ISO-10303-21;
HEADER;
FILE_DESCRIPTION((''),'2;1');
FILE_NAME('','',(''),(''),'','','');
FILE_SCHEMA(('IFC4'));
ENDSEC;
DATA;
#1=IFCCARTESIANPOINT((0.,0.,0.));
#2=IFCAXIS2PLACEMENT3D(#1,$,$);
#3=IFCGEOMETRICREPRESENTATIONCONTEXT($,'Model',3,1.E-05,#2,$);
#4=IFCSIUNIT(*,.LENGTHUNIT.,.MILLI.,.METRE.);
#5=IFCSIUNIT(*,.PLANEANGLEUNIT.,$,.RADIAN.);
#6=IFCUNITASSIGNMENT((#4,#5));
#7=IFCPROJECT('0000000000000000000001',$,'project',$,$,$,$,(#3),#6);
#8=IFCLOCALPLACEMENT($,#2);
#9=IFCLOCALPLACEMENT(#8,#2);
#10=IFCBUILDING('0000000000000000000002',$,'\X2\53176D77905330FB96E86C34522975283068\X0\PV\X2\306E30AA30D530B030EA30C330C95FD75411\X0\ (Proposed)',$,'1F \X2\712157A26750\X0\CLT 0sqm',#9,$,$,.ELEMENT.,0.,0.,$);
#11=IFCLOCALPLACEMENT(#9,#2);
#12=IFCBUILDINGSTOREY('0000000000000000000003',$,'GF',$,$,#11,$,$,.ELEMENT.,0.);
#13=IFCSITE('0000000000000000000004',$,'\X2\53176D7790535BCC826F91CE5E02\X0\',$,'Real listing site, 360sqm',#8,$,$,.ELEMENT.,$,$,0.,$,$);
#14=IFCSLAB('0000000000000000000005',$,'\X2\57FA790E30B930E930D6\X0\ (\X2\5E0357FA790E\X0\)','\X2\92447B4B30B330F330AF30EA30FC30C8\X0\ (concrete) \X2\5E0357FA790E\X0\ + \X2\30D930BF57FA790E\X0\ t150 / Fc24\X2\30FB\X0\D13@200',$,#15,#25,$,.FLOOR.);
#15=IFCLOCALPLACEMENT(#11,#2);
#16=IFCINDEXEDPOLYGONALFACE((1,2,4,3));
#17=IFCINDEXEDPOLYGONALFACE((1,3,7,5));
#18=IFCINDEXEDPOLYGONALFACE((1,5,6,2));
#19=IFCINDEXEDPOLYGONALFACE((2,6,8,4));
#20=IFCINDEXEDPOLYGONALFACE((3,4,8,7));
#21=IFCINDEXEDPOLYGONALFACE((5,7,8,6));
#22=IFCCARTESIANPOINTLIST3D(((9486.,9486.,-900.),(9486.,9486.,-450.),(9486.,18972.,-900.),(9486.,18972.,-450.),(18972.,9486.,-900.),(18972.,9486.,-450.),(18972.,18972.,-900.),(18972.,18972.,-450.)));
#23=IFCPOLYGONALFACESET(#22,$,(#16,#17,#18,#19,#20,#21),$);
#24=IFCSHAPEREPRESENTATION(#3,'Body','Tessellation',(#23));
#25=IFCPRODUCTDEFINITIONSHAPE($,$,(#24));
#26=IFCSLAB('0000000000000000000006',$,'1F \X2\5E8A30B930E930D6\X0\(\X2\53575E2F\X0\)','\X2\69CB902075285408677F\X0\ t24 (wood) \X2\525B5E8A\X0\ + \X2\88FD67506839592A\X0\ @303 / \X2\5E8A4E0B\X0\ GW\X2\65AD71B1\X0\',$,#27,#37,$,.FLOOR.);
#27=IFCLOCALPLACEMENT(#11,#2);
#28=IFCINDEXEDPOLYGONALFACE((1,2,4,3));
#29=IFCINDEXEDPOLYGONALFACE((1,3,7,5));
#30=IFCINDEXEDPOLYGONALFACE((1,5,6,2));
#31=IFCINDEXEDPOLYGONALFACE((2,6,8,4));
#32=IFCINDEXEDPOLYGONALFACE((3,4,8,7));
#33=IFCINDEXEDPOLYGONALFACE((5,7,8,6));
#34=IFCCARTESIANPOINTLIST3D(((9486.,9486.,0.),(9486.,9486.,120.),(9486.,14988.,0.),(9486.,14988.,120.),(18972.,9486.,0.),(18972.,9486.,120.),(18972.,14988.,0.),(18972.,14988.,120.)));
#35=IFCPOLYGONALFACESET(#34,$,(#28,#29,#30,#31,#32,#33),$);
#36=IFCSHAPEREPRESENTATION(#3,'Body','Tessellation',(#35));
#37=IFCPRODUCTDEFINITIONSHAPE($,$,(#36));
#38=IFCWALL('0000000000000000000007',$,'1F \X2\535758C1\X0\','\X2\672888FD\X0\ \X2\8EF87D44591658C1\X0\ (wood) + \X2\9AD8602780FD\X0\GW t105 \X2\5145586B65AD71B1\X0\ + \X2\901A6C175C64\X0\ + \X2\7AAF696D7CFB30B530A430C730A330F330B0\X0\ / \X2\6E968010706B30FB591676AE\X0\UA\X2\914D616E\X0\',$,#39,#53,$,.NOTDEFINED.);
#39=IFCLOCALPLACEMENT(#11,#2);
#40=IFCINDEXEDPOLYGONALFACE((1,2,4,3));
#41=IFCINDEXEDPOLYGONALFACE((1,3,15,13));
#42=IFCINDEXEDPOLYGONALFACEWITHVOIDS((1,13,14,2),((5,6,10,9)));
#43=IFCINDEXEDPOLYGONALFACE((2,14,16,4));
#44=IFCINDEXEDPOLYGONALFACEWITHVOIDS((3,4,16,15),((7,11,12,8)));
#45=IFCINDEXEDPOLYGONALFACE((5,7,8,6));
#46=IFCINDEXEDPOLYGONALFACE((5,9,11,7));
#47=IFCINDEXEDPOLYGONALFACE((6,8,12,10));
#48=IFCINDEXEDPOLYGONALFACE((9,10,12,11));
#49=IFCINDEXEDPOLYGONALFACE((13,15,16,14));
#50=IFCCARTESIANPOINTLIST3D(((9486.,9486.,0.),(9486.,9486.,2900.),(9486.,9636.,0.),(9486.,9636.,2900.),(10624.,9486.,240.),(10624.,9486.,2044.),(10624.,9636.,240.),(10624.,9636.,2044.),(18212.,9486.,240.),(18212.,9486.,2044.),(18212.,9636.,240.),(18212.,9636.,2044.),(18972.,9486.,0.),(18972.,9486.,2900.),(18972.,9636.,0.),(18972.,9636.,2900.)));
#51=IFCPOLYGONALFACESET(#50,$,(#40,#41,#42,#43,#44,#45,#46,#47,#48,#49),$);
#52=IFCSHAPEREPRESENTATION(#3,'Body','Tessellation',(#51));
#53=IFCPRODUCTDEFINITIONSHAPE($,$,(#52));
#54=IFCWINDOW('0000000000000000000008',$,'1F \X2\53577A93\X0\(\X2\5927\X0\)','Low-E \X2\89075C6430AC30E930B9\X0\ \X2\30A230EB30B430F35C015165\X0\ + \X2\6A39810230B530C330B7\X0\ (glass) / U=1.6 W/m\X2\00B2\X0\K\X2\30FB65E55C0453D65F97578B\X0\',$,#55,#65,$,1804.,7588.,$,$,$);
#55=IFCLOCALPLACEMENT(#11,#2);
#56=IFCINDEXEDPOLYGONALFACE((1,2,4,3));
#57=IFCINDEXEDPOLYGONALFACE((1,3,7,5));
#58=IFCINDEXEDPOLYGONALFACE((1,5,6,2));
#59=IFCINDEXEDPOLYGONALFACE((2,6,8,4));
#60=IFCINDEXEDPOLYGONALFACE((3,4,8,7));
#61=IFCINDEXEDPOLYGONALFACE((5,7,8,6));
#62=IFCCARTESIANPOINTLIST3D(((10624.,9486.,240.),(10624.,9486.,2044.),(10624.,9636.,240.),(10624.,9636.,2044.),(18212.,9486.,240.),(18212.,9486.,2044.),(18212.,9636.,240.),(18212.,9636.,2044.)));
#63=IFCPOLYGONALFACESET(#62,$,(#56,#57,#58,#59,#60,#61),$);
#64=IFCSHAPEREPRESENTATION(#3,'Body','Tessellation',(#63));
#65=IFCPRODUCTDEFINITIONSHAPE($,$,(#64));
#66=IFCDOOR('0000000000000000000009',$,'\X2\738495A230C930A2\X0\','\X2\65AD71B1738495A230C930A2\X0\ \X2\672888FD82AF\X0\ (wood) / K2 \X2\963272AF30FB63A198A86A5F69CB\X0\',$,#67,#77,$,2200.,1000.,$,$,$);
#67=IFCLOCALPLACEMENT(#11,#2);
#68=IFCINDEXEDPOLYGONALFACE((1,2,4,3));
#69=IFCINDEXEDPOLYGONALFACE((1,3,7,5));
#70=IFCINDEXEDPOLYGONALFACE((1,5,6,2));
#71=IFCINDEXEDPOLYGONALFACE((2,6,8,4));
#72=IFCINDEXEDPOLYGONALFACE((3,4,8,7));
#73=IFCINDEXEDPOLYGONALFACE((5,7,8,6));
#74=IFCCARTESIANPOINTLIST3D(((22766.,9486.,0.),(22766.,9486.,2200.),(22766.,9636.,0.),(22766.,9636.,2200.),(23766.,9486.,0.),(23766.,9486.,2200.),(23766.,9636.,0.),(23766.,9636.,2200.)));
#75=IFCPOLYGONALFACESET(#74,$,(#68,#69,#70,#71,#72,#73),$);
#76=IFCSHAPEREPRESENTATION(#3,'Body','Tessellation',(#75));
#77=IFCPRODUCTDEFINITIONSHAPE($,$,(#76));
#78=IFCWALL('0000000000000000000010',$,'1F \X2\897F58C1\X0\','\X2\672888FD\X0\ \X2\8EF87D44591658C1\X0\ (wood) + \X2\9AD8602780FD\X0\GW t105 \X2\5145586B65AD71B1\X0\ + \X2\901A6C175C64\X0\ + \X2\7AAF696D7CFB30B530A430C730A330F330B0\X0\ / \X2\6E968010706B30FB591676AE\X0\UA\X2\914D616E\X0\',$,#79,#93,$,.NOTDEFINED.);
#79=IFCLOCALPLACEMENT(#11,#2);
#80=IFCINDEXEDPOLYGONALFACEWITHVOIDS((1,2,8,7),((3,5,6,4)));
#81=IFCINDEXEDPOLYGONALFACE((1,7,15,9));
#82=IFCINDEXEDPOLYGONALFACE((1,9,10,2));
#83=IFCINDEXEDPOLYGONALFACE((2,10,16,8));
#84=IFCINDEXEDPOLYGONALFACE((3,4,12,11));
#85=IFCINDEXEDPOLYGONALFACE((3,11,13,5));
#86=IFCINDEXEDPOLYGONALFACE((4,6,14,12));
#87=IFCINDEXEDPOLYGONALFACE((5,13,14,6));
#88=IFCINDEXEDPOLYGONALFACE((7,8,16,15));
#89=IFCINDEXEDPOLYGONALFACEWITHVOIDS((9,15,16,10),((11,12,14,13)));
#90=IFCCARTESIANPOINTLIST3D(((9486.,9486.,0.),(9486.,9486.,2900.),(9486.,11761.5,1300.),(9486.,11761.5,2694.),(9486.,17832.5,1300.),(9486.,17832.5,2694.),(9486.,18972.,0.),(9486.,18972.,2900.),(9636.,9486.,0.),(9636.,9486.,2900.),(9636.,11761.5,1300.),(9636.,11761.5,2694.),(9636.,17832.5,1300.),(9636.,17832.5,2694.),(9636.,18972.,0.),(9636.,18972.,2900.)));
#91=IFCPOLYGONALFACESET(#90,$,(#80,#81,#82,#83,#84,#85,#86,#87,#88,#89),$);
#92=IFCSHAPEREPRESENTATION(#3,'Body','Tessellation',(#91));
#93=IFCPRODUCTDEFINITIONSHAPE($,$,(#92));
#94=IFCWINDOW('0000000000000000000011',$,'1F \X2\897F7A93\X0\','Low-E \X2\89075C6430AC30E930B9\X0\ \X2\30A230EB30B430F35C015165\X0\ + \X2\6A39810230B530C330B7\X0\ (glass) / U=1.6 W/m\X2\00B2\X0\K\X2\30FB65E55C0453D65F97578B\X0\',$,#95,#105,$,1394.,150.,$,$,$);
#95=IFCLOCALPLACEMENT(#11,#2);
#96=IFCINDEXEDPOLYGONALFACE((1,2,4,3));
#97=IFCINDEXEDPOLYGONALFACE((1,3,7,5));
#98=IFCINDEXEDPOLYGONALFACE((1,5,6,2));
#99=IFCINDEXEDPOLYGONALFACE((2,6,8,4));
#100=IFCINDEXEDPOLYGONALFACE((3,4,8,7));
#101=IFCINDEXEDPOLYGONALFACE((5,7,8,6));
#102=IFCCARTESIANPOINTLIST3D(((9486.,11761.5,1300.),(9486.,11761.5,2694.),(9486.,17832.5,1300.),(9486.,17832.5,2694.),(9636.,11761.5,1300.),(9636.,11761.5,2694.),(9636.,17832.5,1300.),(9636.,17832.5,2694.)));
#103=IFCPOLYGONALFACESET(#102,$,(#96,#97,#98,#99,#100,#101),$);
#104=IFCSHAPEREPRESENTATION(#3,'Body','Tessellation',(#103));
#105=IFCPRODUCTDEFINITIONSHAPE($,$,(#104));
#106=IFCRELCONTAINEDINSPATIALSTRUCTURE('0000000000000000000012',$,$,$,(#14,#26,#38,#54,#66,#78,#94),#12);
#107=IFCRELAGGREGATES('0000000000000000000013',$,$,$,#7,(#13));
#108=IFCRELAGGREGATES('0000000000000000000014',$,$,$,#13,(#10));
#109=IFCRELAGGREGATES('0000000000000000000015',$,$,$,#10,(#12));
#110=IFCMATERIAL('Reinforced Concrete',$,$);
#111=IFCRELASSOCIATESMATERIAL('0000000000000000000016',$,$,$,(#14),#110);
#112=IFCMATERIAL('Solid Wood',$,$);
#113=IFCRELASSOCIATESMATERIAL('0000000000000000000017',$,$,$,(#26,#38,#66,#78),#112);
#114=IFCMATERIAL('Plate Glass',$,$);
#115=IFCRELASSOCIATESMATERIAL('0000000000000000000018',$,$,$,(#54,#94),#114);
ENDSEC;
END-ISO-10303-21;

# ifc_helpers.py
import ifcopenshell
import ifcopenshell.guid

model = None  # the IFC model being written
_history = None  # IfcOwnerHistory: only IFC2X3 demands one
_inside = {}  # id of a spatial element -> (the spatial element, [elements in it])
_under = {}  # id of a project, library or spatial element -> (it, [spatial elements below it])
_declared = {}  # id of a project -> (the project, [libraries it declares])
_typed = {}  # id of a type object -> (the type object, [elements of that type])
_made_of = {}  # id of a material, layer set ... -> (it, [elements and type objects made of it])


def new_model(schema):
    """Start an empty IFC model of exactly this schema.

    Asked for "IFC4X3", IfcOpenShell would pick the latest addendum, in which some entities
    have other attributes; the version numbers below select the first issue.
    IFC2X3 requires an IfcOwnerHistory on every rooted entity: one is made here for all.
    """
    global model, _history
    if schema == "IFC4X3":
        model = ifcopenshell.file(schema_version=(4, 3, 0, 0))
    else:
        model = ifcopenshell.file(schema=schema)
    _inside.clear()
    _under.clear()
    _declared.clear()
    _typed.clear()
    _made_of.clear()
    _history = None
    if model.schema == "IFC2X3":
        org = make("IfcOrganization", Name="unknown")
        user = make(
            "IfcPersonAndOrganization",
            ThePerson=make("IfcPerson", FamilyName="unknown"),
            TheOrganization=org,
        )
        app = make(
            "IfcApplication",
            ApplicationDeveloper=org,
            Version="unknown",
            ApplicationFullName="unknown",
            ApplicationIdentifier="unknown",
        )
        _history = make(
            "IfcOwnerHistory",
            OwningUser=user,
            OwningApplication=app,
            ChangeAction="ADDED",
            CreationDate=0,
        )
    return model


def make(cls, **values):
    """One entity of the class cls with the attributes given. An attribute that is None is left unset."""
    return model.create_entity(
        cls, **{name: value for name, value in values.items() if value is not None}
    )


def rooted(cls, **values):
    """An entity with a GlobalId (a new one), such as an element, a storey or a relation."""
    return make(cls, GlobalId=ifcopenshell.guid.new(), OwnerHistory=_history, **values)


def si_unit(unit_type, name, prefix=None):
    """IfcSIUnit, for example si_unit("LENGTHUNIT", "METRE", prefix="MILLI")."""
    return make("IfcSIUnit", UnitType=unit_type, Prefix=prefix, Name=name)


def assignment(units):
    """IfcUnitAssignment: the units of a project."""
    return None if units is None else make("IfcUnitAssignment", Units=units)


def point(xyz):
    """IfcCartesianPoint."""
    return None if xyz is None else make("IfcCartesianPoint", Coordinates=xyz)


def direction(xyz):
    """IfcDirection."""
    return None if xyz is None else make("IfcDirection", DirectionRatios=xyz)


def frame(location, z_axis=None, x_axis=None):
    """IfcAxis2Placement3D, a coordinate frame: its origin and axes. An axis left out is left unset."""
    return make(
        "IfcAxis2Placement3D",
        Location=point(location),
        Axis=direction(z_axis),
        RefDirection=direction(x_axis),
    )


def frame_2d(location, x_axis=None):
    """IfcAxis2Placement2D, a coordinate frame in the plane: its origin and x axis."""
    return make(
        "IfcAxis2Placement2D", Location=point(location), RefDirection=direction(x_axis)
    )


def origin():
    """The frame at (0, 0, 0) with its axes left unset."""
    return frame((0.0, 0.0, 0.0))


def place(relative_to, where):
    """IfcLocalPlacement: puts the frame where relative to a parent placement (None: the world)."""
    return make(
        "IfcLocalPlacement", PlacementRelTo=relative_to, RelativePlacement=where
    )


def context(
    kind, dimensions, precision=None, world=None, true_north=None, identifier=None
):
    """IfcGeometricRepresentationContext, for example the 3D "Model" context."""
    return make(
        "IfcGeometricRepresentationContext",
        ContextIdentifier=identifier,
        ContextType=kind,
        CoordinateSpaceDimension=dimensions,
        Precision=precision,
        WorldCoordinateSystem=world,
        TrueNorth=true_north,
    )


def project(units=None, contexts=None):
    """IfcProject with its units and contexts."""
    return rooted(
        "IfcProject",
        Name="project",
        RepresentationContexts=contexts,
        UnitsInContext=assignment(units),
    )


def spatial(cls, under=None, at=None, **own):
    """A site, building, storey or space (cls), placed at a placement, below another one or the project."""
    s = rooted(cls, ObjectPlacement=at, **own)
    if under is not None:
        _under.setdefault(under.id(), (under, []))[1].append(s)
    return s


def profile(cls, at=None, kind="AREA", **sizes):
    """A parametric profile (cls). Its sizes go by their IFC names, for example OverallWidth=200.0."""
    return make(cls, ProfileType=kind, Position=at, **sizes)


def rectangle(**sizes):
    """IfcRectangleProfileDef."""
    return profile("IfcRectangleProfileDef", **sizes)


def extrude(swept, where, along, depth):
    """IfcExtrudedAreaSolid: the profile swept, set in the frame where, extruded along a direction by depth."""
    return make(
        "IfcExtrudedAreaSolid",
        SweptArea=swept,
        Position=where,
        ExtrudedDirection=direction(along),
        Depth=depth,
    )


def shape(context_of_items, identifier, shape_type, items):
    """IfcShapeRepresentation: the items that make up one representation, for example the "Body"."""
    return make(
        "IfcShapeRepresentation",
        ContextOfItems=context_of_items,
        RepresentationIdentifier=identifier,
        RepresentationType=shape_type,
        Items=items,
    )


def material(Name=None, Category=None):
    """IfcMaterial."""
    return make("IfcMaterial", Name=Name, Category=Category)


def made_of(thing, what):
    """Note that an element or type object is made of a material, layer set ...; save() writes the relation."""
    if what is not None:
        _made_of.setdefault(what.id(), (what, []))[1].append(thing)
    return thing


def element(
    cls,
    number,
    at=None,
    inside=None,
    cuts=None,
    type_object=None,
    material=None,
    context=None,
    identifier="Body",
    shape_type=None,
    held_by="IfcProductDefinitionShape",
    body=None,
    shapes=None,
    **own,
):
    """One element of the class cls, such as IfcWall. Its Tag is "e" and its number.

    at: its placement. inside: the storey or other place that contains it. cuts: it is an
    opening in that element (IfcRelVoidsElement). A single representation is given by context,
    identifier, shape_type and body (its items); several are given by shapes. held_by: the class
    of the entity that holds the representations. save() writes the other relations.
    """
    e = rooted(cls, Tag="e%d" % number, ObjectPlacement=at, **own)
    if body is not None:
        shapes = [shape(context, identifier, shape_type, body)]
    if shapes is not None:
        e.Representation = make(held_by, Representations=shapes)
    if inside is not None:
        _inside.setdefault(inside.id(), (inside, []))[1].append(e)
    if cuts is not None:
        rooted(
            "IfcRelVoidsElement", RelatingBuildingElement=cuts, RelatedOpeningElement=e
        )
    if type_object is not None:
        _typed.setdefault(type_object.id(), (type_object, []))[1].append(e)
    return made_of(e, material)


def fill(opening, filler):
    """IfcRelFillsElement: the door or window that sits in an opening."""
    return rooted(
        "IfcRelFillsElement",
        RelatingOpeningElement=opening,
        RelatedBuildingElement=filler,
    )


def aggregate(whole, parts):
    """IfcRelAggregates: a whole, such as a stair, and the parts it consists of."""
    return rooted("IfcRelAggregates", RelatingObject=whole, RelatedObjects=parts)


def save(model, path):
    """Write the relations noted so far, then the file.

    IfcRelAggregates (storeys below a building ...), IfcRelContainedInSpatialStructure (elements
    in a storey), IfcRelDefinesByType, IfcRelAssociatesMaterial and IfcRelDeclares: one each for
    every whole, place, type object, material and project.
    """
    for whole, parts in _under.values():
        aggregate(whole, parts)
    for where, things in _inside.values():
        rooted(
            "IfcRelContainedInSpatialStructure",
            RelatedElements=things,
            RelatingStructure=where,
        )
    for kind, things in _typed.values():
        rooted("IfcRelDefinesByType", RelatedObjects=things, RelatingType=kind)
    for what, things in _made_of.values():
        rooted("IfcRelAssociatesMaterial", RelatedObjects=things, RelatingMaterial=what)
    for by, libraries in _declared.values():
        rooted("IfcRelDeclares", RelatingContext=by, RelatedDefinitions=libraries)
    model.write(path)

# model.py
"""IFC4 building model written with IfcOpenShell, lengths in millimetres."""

from ifc_helpers import new_model, si_unit, frame, frame_2d, origin, place, context, project, spatial, rectangle, extrude, material, element, fill, save


model = new_model("IFC4")

# Units and contexts
model_context = context("Model", 3, precision=1e-05, world=origin())
ifc_project = project(units=[si_unit("LENGTHUNIT", "METRE", prefix="MILLI"), si_unit("PLANEANGLEUNIT", "RADIAN")], contexts=[model_context])

# Site, building, storey
site_placement = place(None, origin())
site = spatial("IfcSite", under=ifc_project, at=site_placement, Name="北海道富良野市", ObjectType="Real listing site, 360sqm", CompositionType="ELEMENT", RefElevation=0.0)
building_placement = place(site_placement, origin())
building = spatial("IfcBuilding", under=site, at=building_placement, Name="北海道・雨水利用とPVのオフグリッド志向 (Proposed)", ObjectType="1F 無垢材CLT 0sqm", CompositionType="ELEMENT", ElevationOfRefHeight=0.0, ElevationOfTerrain=0.0)
storey_placement = place(building_placement, origin())
storey = spatial("IfcBuildingStorey", under=building, at=storey_placement, Name="GF", CompositionType="ELEMENT", Elevation=0.0)

# Slabs
ifc_material_1 = material(Name="Reinforced Concrete")
slab_1_placement = place(storey_placement, frame((4743.0, 4743.0, -450.0)))
element("IfcSlab", 1, at=slab_1_placement, inside=storey, material=ifc_material_1, Name="基礎スラブ (布基礎)", Description="鉄筋コンクリート (concrete) 布基礎 + ベタ基礎 t150 / Fc24・D13@200", PredefinedType="FLOOR", context=model_context, shape_type="SweptSolid", body=[
    extrude(rectangle(XDim=9486.0, YDim=9486.0, at=frame_2d((4743.0, 4743.0))), frame((4743.0, 4743.0, -450.0)), (0.0, 0.0, 1.0), 450.0),
])
ifc_material_2 = material(Name="Solid Wood")
slab_2_placement = place(storey_placement, frame((4743.0, 4743.0, 0.0)))
element("IfcSlab", 2, at=slab_2_placement, inside=storey, material=ifc_material_2, Name="1F 床スラブ(南帯)", Description="構造用合板 t24 (wood) 剛床 + 製材根太 @303 / 床下 GW断熱", PredefinedType="FLOOR", context=model_context, shape_type="SweptSolid", body=[
    extrude(rectangle(XDim=9486.0, YDim=5502.0, at=frame_2d((4743.0, 2751.0))), frame((4743.0, 4743.0, 0.0)), (0.0, 0.0, 1.0), 120.0),
])

# Wall, openings, window, door
wall_1_placement = place(storey_placement, frame((4743.0, 4743.0, 0.0)))
wall_1 = element("IfcWall", 3, at=wall_1_placement, inside=storey, material=ifc_material_2, Name="1F 南壁", Description="木製 軸組外壁 (wood) + 高性能GW t105 充填断熱 + 通気層 + 窯業系サイディング / 準耐火・外皮UA配慮", PredefinedType="NOTDEFINED", context=model_context, shape_type="SweptSolid", body=[
    extrude(rectangle(XDim=9486.0, YDim=150.0, at=frame_2d((4743.0, 75.0))), frame((4743.0, 4743.0, 0.0)), (0.0, 0.0, 1.0), 2900.0),
])
opening_1_placement = place(storey_placement, frame((5312.0, 4743.0, 120.0)))
opening_1 = element("IfcOpeningElement", 4, at=opening_1_placement, cuts=wall_1, PredefinedType="NOTDEFINED", context=model_context, shape_type="SweptSolid", body=[
    extrude(rectangle(XDim=7588.0, YDim=150.0, at=frame_2d((3794.0, 75.0))), frame((5312.0, 4743.0, 120.0)), (0.0, 0.0, 1.0), 1804.0),
])
opening_2_placement = place(storey_placement, frame((11383.0, 4743.0, 0.0)))
opening_2 = element("IfcOpeningElement", 5, at=opening_2_placement, cuts=wall_1, PredefinedType="NOTDEFINED", context=model_context, shape_type="SweptSolid", body=[
    extrude(rectangle(XDim=1000.0, YDim=150.0, at=frame_2d((500.0, 75.0))), frame((11383.0, 4743.0, 0.0)), (0.0, 0.0, 1.0), 2200.0),
])
ifc_material_3 = material(Name="Plate Glass")
window_1_placement = place(storey_placement, frame((5312.0, 4743.0, 120.0)))
window_1 = element("IfcWindow", 6, at=window_1_placement, inside=storey, material=ifc_material_3, Name="1F 南窓(大)", Description="Low-E 複層ガラス アルゴン封入 + 樹脂サッシ (glass) / U=1.6 W/m²K・日射取得型", OverallHeight=1804.0, OverallWidth=7588.0, context=model_context, shape_type="SweptSolid", body=[
    extrude(rectangle(XDim=7588.0, YDim=150.0, at=frame_2d((3794.0, 75.0))), frame((5312.0, 4743.0, 120.0)), (0.0, 0.0, 1.0), 1804.0),
])
fill(opening_1, window_1)
door_placement = place(storey_placement, frame((11383.0, 4743.0, 0.0)))
door = element("IfcDoor", 7, at=door_placement, inside=storey, material=ifc_material_2, Name="玄関ドア", Description="断熱玄関ドア 木製芯 (wood) / K2 防犯・採風機構", OverallHeight=2200.0, OverallWidth=1000.0, context=model_context, shape_type="SweptSolid", body=[
    extrude(rectangle(XDim=1000.0, YDim=150.0, at=frame_2d((500.0, 75.0))), frame((11383.0, 4743.0, 0.0)), (0.0, 0.0, 1.0), 2200.0),
])
fill(opening_2, door)

# Wall, opening, window
wall_2_placement = place(storey_placement, frame((4743.0, 4743.0, 0.0)))
wall_2 = element("IfcWall", 8, at=wall_2_placement, inside=storey, material=ifc_material_2, Name="1F 西壁", Description="木製 軸組外壁 (wood) + 高性能GW t105 充填断熱 + 通気層 + 窯業系サイディング / 準耐火・外皮UA配慮", PredefinedType="NOTDEFINED", context=model_context, shape_type="SweptSolid", body=[
    extrude(rectangle(XDim=150.0, YDim=9486.0, at=frame_2d((75.0, 4743.0))), frame((4743.0, 4743.0, 0.0)), (0.0, 0.0, 1.0), 2900.0),
])
opening_3_placement = place(storey_placement, frame((4743.0, 5881.0, 650.0)))
opening_3 = element("IfcOpeningElement", 9, at=opening_3_placement, cuts=wall_2, PredefinedType="NOTDEFINED", context=model_context, shape_type="SweptSolid", body=[
    extrude(rectangle(XDim=150.0, YDim=6071.0, at=frame_2d((75.0, 3035.0))), frame((4743.0, 5881.0, 650.0)), (0.0, 0.0, 1.0), 1394.0),
])
window_2_placement = place(storey_placement, frame((4743.0, 5881.0, 650.0)))
window_2 = element("IfcWindow", 10, at=window_2_placement, inside=storey, material=ifc_material_3, Name="1F 西窓", Description="Low-E 複層ガラス アルゴン封入 + 樹脂サッシ (glass) / U=1.6 W/m²K・日射取得型", OverallHeight=1394.0, OverallWidth=150.0, context=model_context, shape_type="SweptSolid", body=[
    extrude(rectangle(XDim=150.0, YDim=6071.0, at=frame_2d((75.0, 3035.0))), frame((4743.0, 5881.0, 650.0)), (0.0, 0.0, 1.0), 1394.0),
])
fill(opening_3, window_2)

save(model, "model.ifc")
